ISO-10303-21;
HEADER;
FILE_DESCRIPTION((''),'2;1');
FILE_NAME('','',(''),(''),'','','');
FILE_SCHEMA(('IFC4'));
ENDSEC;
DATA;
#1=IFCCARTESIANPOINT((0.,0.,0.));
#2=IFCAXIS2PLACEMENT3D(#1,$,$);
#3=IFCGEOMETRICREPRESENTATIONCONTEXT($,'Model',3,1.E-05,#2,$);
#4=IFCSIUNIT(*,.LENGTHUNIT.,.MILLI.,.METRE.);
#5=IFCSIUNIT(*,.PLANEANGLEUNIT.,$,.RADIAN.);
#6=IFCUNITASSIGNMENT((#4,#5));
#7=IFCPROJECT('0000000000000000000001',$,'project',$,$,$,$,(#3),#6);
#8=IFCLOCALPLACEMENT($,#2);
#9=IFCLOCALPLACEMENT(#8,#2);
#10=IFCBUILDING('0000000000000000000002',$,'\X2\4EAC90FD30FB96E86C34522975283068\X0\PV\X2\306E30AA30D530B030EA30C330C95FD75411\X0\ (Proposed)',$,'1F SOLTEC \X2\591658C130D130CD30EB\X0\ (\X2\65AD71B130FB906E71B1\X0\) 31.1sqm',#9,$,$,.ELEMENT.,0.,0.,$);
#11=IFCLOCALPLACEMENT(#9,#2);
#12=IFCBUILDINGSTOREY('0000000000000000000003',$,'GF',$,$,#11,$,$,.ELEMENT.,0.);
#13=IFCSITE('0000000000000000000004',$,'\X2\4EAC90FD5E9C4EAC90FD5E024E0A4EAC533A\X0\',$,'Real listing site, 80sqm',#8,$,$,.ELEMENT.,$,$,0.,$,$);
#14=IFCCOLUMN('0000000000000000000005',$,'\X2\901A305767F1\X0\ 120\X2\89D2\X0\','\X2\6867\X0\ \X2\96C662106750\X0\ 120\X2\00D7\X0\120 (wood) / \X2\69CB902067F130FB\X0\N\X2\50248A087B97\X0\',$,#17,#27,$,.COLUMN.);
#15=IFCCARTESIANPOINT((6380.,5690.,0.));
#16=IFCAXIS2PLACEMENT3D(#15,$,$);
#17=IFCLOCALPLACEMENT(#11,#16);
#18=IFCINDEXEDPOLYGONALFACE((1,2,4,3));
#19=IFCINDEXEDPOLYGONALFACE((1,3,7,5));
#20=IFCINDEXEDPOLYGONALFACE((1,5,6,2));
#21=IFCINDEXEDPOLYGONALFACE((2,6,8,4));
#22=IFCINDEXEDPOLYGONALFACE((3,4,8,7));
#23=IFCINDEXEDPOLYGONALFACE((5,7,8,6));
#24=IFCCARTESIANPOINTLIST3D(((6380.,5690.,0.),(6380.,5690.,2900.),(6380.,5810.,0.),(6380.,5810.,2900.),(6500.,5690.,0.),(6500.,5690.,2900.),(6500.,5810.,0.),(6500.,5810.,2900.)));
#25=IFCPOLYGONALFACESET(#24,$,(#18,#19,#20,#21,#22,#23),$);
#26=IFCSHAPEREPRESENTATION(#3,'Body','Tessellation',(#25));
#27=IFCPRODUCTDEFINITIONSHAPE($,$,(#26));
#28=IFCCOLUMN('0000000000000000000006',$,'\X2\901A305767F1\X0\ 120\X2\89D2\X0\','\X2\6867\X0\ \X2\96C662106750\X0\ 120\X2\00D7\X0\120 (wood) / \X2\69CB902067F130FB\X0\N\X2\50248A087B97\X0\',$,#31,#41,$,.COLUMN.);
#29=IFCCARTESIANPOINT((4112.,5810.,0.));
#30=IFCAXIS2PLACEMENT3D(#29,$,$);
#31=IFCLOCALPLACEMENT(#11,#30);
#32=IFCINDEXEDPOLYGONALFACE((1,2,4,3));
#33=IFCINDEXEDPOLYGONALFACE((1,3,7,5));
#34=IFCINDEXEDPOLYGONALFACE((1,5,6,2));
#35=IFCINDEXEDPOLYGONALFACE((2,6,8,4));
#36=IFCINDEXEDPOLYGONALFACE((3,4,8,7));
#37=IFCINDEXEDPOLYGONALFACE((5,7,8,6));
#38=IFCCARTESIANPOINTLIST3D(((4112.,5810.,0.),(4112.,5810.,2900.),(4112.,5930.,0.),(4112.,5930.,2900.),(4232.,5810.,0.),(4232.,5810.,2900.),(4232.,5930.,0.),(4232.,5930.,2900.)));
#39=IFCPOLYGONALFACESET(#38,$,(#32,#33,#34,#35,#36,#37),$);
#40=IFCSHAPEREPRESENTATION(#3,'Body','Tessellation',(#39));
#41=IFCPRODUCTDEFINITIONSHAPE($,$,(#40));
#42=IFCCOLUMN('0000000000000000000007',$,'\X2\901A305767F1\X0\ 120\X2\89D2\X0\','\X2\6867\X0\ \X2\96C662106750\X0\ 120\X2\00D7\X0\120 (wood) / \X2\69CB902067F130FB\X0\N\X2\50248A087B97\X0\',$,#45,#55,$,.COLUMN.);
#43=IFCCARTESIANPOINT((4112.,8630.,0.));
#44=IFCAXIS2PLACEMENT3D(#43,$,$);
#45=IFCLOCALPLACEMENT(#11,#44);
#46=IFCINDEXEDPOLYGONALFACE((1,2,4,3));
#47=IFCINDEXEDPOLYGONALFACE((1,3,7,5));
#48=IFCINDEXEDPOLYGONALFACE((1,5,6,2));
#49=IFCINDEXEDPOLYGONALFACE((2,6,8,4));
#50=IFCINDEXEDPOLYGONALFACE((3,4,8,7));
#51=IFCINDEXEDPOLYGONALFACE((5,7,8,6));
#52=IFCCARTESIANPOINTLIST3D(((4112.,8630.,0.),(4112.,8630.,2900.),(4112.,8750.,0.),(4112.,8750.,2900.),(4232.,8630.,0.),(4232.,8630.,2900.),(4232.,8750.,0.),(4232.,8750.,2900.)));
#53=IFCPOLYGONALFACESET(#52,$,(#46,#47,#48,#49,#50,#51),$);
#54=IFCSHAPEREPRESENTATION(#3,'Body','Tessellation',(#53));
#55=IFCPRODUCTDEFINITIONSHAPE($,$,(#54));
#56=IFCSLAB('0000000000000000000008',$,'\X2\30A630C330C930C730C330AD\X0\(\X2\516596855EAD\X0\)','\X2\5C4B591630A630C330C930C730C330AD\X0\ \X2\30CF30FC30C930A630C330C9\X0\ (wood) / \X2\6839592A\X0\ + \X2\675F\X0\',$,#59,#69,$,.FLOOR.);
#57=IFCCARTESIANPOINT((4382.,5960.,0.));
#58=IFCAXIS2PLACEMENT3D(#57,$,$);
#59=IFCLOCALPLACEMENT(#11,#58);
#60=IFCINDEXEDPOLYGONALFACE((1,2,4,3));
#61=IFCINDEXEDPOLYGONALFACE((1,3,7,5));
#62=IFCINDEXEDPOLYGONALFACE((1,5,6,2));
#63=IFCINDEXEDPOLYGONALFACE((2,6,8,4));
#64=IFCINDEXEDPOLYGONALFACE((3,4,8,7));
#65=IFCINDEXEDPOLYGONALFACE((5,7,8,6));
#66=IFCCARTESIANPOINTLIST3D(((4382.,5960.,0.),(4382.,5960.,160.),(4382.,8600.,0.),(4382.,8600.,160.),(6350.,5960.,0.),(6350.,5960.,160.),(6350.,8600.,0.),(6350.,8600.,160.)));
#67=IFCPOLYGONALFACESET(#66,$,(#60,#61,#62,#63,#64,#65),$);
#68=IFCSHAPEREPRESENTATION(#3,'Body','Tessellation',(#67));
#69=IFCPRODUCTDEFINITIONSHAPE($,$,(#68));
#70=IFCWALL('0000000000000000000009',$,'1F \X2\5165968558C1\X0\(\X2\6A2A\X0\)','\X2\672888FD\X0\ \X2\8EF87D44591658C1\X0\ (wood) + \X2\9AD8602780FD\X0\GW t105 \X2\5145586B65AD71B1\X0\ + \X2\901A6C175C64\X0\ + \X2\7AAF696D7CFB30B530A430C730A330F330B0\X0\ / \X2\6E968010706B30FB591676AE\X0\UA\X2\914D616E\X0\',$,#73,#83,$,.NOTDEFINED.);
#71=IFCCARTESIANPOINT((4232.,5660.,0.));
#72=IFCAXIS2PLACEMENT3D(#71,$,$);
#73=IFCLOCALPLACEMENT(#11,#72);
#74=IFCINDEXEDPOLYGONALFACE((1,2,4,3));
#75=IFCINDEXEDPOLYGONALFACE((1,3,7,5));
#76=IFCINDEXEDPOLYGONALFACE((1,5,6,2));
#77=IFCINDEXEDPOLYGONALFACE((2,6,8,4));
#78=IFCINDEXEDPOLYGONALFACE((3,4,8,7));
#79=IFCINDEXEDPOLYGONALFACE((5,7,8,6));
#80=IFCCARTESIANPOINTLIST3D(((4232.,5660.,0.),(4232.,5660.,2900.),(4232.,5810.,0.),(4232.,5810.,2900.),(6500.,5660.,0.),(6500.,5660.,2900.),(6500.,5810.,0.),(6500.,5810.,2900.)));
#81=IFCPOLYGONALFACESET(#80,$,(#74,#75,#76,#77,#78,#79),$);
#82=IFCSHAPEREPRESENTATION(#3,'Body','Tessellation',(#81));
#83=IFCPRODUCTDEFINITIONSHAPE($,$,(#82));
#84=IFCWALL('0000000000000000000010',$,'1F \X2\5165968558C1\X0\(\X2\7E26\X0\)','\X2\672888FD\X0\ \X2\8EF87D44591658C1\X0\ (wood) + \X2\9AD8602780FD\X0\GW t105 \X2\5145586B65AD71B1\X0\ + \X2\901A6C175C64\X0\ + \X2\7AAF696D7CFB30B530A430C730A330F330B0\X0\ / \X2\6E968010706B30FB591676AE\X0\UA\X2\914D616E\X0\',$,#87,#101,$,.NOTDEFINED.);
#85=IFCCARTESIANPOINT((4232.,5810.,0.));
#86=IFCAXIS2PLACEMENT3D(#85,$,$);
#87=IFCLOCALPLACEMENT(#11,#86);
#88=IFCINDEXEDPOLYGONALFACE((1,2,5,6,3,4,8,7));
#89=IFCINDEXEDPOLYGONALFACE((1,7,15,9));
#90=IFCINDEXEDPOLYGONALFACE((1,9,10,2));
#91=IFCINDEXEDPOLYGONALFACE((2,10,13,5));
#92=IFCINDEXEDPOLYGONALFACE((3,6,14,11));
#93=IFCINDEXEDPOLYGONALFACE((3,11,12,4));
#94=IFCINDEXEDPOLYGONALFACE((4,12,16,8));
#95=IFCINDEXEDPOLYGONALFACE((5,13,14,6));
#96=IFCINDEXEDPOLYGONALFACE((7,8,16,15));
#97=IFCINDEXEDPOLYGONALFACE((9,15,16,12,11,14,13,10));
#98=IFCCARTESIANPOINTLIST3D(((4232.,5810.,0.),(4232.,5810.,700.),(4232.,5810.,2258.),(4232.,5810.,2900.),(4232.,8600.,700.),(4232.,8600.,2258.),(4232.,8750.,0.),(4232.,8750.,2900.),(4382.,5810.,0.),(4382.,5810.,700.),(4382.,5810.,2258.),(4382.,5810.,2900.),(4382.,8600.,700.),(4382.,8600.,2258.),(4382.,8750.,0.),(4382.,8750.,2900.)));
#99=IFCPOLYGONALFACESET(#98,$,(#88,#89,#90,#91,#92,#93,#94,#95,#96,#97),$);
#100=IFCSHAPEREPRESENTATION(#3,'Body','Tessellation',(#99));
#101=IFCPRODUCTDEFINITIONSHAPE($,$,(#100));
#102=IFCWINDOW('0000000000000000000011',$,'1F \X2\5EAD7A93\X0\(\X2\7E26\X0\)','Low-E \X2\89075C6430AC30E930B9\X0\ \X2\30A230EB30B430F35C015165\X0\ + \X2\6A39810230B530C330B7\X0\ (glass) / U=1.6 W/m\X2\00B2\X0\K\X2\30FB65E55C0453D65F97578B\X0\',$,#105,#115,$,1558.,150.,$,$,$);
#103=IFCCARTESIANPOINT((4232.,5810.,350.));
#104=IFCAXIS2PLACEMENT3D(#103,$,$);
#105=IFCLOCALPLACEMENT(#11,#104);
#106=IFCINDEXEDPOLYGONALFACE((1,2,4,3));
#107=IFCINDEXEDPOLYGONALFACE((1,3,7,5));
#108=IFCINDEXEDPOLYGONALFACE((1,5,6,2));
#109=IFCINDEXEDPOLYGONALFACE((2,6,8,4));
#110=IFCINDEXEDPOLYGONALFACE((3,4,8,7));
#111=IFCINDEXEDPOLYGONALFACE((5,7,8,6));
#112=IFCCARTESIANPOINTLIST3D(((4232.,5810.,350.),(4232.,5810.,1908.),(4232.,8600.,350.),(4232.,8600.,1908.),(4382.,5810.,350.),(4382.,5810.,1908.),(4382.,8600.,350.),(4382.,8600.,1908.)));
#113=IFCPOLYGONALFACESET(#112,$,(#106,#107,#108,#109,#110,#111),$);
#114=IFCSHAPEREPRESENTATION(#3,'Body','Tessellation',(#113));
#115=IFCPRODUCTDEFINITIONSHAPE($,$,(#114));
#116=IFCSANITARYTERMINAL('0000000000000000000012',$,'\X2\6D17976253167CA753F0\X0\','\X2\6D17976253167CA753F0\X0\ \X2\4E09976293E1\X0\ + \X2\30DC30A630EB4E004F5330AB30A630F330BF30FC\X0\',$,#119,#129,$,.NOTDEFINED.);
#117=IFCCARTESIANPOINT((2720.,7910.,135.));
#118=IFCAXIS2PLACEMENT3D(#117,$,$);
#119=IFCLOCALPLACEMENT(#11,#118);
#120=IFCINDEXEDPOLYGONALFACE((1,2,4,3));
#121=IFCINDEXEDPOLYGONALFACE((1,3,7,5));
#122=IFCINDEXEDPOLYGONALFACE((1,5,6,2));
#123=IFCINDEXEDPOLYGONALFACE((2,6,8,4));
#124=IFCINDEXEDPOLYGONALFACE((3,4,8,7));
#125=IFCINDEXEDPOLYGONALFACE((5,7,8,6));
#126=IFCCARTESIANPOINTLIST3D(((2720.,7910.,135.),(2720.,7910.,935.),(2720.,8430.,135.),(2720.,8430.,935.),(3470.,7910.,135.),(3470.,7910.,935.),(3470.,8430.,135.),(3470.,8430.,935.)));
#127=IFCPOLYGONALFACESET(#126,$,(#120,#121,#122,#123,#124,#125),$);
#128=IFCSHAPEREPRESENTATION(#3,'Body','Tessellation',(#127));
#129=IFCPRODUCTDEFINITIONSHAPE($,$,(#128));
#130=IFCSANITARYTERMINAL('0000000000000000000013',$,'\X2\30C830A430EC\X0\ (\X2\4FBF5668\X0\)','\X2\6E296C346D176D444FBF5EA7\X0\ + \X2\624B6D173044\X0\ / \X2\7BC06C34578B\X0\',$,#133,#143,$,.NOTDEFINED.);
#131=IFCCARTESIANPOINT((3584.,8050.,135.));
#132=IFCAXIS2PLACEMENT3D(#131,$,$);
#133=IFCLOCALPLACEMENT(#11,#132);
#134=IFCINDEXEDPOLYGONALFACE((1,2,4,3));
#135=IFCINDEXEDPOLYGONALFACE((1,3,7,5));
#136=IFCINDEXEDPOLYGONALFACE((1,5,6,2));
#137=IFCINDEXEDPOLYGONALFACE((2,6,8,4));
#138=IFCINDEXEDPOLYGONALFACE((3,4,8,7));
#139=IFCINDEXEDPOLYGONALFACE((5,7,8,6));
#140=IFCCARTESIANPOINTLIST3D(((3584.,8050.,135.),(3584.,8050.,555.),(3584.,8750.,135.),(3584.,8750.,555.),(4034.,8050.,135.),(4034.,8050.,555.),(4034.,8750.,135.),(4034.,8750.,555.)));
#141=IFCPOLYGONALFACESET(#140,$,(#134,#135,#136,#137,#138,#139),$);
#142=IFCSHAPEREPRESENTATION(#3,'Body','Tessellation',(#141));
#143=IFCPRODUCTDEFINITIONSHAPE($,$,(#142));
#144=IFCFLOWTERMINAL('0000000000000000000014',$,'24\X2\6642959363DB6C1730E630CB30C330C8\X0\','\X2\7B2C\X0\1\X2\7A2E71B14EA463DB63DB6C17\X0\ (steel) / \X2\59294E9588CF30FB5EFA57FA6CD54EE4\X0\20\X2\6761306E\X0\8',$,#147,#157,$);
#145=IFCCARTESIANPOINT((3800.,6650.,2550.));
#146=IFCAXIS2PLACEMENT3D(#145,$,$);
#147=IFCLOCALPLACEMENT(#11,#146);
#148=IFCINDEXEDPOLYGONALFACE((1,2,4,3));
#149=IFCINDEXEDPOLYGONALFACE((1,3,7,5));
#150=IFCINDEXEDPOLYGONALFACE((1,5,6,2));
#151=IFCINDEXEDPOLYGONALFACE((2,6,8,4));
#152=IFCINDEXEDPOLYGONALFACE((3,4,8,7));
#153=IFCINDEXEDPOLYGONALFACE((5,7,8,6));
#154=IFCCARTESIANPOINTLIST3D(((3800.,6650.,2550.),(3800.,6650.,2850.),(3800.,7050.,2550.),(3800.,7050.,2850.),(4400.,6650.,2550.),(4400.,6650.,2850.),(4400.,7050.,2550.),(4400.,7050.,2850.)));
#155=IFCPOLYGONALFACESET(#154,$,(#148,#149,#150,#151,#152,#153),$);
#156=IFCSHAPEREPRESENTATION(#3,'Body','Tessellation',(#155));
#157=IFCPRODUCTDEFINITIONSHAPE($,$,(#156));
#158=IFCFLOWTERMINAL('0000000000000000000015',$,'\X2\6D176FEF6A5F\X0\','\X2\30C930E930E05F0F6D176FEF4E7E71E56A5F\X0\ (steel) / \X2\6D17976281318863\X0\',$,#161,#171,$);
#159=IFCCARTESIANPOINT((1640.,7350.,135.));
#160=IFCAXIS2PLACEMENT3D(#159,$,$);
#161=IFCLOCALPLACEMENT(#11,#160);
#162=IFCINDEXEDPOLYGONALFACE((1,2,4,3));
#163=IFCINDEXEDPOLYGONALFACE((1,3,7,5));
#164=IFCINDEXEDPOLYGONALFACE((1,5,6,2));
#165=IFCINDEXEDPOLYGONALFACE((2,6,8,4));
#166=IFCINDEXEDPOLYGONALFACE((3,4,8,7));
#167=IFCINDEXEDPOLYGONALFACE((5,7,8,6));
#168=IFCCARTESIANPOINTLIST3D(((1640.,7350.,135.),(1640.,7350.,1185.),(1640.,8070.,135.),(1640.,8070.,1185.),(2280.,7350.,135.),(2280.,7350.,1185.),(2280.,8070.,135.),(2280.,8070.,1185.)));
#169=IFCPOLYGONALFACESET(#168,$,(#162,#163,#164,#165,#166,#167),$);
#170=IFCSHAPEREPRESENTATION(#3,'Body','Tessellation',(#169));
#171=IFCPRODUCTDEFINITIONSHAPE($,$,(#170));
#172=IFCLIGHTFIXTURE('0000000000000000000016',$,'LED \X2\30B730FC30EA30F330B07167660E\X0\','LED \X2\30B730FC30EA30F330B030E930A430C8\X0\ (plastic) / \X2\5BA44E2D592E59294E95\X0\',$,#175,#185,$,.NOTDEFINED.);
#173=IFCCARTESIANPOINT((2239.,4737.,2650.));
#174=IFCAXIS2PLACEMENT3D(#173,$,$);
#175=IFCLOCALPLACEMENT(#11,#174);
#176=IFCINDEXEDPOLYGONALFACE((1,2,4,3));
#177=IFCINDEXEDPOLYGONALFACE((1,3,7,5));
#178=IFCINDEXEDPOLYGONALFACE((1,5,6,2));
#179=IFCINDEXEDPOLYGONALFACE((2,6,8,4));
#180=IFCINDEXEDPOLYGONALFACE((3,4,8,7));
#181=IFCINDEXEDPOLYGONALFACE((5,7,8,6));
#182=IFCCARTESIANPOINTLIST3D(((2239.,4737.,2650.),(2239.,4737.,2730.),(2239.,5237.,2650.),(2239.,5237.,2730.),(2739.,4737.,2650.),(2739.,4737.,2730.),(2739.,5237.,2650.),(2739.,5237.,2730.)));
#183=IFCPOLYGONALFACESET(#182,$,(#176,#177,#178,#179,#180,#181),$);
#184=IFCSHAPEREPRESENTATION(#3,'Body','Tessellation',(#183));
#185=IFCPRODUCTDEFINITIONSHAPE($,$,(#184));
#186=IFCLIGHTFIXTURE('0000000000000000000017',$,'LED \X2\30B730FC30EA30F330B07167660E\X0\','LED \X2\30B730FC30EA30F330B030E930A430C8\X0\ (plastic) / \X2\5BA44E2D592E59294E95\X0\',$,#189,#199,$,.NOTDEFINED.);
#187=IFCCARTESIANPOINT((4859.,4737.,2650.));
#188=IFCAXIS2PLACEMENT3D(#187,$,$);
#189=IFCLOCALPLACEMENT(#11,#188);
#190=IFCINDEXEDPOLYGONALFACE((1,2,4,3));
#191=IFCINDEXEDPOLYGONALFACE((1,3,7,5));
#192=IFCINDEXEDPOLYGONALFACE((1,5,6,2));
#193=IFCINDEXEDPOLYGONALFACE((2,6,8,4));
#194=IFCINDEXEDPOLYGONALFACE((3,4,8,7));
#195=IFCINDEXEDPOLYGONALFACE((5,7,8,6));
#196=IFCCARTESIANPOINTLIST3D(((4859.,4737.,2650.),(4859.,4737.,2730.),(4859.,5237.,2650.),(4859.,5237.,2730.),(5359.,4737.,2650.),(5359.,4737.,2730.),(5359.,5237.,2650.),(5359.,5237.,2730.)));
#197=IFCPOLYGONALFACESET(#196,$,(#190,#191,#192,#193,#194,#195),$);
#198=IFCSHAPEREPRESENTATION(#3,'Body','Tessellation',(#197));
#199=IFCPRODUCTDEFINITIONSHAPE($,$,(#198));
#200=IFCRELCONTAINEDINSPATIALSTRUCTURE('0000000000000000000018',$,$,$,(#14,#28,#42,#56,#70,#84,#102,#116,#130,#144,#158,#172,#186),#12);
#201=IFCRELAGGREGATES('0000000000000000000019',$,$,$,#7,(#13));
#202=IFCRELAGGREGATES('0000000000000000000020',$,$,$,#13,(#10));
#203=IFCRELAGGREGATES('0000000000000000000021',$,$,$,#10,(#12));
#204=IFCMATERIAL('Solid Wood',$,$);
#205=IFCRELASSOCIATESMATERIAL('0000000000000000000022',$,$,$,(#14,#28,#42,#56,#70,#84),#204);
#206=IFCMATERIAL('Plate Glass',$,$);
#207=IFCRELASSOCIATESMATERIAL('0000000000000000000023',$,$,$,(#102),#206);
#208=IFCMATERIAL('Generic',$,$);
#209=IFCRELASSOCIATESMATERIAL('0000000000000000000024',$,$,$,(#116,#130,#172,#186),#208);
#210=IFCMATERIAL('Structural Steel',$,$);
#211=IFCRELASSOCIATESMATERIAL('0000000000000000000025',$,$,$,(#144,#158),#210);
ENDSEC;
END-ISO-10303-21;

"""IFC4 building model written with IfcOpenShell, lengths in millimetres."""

from ifc_helpers import new_model, si_unit, frame, frame_2d, origin, place, context, project, spatial, rectangle, extrude, material, element, fill, save


model = new_model("IFC4")

# Units and contexts
model_context = context("Model", 3, precision=1e-05, world=origin())
ifc_project = project(units=[si_unit("LENGTHUNIT", "METRE", prefix="MILLI"), si_unit("PLANEANGLEUNIT", "RADIAN")], contexts=[model_context])

# Site, building, storey
site_placement = place(None, origin())
site = spatial("IfcSite", under=ifc_project, at=site_placement, Name="京都府京都市上京区", ObjectType="Real listing site, 80sqm", CompositionType="ELEMENT", RefElevation=0.0)
building_placement = place(site_placement, origin())
building = spatial("IfcBuilding", under=site, at=building_placement, Name="京都・雨水利用とPVのオフグリッド志向 (Proposed)", ObjectType="1F SOLTEC 外壁パネル (断熱・遮熱) 31.1sqm", CompositionType="ELEMENT", ElevationOfRefHeight=0.0, ElevationOfTerrain=0.0)
storey_placement = place(building_placement, origin())
storey = spatial("IfcBuildingStorey", under=building, at=storey_placement, Name="GF", CompositionType="ELEMENT", Elevation=0.0)

# Columns
ifc_material_1 = material(Name="Solid Wood")
column_1_placement = place(storey_placement, frame((6380.0, 5690.0, 0.0)))
element("IfcColumn", 1, at=column_1_placement, inside=storey, material=ifc_material_1, Name="通し柱 120角", Description="桧 集成材 120×120 (wood) / 構造柱・N値計算", PredefinedType="COLUMN", context=model_context, shape_type="SweptSolid", body=[
    extrude(rectangle(XDim=120.0, YDim=120.0, at=frame_2d((60.0, 60.0))), frame((6380.0, 5690.0, 0.0)), (0.0, 0.0, 1.0), 2900.0),
])
column_2_placement = place(storey_placement, frame((4112.0, 5810.0, 0.0)))
element("IfcColumn", 2, at=column_2_placement, inside=storey, material=ifc_material_1, Name="通し柱 120角", Description="桧 集成材 120×120 (wood) / 構造柱・N値計算", PredefinedType="COLUMN", context=model_context, shape_type="SweptSolid", body=[
    extrude(rectangle(XDim=120.0, YDim=120.0, at=frame_2d((60.0, 60.0))), frame((4112.0, 5810.0, 0.0)), (0.0, 0.0, 1.0), 2900.0),
])
column_3_placement = place(storey_placement, frame((4112.0, 8630.0, 0.0)))
element("IfcColumn", 3, at=column_3_placement, inside=storey, material=ifc_material_1, Name="通し柱 120角", Description="桧 集成材 120×120 (wood) / 構造柱・N値計算", PredefinedType="COLUMN", context=model_context, shape_type="SweptSolid", body=[
    extrude(rectangle(XDim=120.0, YDim=120.0, at=frame_2d((60.0, 60.0))), frame((4112.0, 8630.0, 0.0)), (0.0, 0.0, 1.0), 2900.0),
])

# Slab
slab_placement = place(storey_placement, frame((4382.0, 5960.0, 0.0)))
element("IfcSlab", 4, at=slab_placement, inside=storey, material=ifc_material_1, Name="ウッドデッキ(入隅庭)", Description="屋外ウッドデッキ ハードウッド (wood) / 根太 + 束", PredefinedType="FLOOR", context=model_context, shape_type="SweptSolid", body=[
    extrude(rectangle(XDim=1968.0, YDim=2640.0, at=frame_2d((984.0, 1320.0))), frame((4382.0, 5960.0, 0.0)), (0.0, 0.0, 1.0), 160.0),
])

# Wall
wall_1_placement = place(storey_placement, frame((4232.0, 5660.0, 0.0)))
element("IfcWall", 5, at=wall_1_placement, inside=storey, material=ifc_material_1, Name="1F 入隅壁(横)", Description="木製 軸組外壁 (wood) + 高性能GW t105 充填断熱 + 通気層 + 窯業系サイディング / 準耐火・外皮UA配慮", PredefinedType="NOTDEFINED", context=model_context, shape_type="SweptSolid", body=[
    extrude(rectangle(XDim=2268.0, YDim=150.0, at=frame_2d((1134.0, 75.0))), frame((4232.0, 5660.0, 0.0)), (0.0, 0.0, 1.0), 2900.0),
])

# Wall, opening, window
wall_2_placement = place(storey_placement, frame((4232.0, 5810.0, 0.0)))
wall_2 = element("IfcWall", 6, at=wall_2_placement, inside=storey, material=ifc_material_1, Name="1F 入隅壁(縦)", Description="木製 軸組外壁 (wood) + 高性能GW t105 充填断熱 + 通気層 + 窯業系サイディング / 準耐火・外皮UA配慮", PredefinedType="NOTDEFINED", context=model_context, shape_type="SweptSolid", body=[
    extrude(rectangle(XDim=150.0, YDim=2940.0, at=frame_2d((75.0, 1470.0))), frame((4232.0, 5810.0, 0.0)), (0.0, 0.0, 1.0), 2900.0),
])
opening_placement = place(storey_placement, frame((4232.0, 5810.0, 350.0)))
opening = element("IfcOpeningElement", 7, at=opening_placement, cuts=wall_2, PredefinedType="NOTDEFINED", context=model_context, shape_type="SweptSolid", body=[
    extrude(rectangle(XDim=150.0, YDim=2790.0, at=frame_2d((75.0, 1395.0))), frame((4232.0, 5810.0, 350.0)), (0.0, 0.0, 1.0), 1558.0),
])
ifc_material_2 = material(Name="Plate Glass")
window_placement = place(storey_placement, frame((4232.0, 5810.0, 350.0)))
window = element("IfcWindow", 8, at=window_placement, inside=storey, material=ifc_material_2, Name="1F 庭窓(縦)", Description="Low-E 複層ガラス アルゴン封入 + 樹脂サッシ (glass) / U=1.6 W/m²K・日射取得型", OverallHeight=1558.0, OverallWidth=150.0, context=model_context, shape_type="SweptSolid", body=[
    extrude(rectangle(XDim=150.0, YDim=2790.0, at=frame_2d((75.0, 1395.0))), frame((4232.0, 5810.0, 350.0)), (0.0, 0.0, 1.0), 1558.0),
])
fill(opening, window)

# Sanitary terminals
ifc_material_3 = material(Name="Generic")
sanitary_terminal_1_placement = place(storey_placement, frame((2720.0, 7910.0, 135.0)))
element("IfcSanitaryTerminal", 9, at=sanitary_terminal_1_placement, inside=storey, material=ifc_material_3, Name="洗面化粧台", Description="洗面化粧台 三面鏡 + ボウル一体カウンター", PredefinedType="NOTDEFINED", context=model_context, shape_type="SweptSolid", body=[
    extrude(rectangle(XDim=750.0, YDim=520.0, at=frame_2d((375.0, 260.0))), frame((2720.0, 7910.0, 135.0)), (0.0, 0.0, 1.0), 800.0),
])
sanitary_terminal_2_placement = place(storey_placement, frame((3584.0, 8050.0, 135.0)))
element("IfcSanitaryTerminal", 10, at=sanitary_terminal_2_placement, inside=storey, material=ifc_material_3, Name="トイレ (便器)", Description="温水洗浄便座 + 手洗い / 節水型", PredefinedType="NOTDEFINED", context=model_context, shape_type="SweptSolid", body=[
    extrude(rectangle(XDim=450.0, YDim=700.0, at=frame_2d((225.0, 350.0))), frame((3584.0, 8050.0, 135.0)), (0.0, 0.0, 1.0), 420.0),
])

# Flow terminals
ifc_material_4 = material(Name="Structural Steel")
flow_terminal_1_placement = place(storey_placement, frame((3800.0, 6650.0, 2550.0)))
element("IfcFlowTerminal", 11, at=flow_terminal_1_placement, inside=storey, material=ifc_material_4, Name="24時間換気ユニット", Description="第1種熱交換換気 (steel) / 天井裏・建基法令20条の8", context=model_context, shape_type="SweptSolid", body=[
    extrude(rectangle(XDim=600.0, YDim=400.0, at=frame_2d((300.0, 200.0))), frame((3800.0, 6650.0, 2550.0)), (0.0, 0.0, 1.0), 300.0),
])
flow_terminal_2_placement = place(storey_placement, frame((1640.0, 7350.0, 135.0)))
element("IfcFlowTerminal", 12, at=flow_terminal_2_placement, inside=storey, material=ifc_material_4, Name="洗濯機", Description="ドラム式洗濯乾燥機 (steel) / 洗面脱衣", context=model_context, shape_type="SweptSolid", body=[
    extrude(rectangle(XDim=640.0, YDim=720.0, at=frame_2d((320.0, 360.0))), frame((1640.0, 7350.0, 135.0)), (0.0, 0.0, 1.0), 1050.0),
])

# Light fixtures
light_fixture_1_placement = place(storey_placement, frame((2239.0, 4737.0, 2650.0)))
element("IfcLightFixture", 13, at=light_fixture_1_placement, inside=storey, material=ifc_material_3, Name="LED シーリング照明", Description="LED シーリングライト (plastic) / 室中央天井", PredefinedType="NOTDEFINED", context=model_context, shape_type="SweptSolid", body=[
    extrude(rectangle(XDim=500.0, YDim=500.0, at=frame_2d((250.0, 250.0))), frame((2239.0, 4737.0, 2650.0)), (0.0, 0.0, 1.0), 80.0),
])
light_fixture_2_placement = place(storey_placement, frame((4859.0, 4737.0, 2650.0)))
element("IfcLightFixture", 14, at=light_fixture_2_placement, inside=storey, material=ifc_material_3, Name="LED シーリング照明", Description="LED シーリングライト (plastic) / 室中央天井", PredefinedType="NOTDEFINED", context=model_context, shape_type="SweptSolid", body=[
    extrude(rectangle(XDim=500.0, YDim=500.0, at=frame_2d((250.0, 250.0))), frame((4859.0, 4737.0, 2650.0)), (0.0, 0.0, 1.0), 80.0),
])

save(model, "model.ifc")
